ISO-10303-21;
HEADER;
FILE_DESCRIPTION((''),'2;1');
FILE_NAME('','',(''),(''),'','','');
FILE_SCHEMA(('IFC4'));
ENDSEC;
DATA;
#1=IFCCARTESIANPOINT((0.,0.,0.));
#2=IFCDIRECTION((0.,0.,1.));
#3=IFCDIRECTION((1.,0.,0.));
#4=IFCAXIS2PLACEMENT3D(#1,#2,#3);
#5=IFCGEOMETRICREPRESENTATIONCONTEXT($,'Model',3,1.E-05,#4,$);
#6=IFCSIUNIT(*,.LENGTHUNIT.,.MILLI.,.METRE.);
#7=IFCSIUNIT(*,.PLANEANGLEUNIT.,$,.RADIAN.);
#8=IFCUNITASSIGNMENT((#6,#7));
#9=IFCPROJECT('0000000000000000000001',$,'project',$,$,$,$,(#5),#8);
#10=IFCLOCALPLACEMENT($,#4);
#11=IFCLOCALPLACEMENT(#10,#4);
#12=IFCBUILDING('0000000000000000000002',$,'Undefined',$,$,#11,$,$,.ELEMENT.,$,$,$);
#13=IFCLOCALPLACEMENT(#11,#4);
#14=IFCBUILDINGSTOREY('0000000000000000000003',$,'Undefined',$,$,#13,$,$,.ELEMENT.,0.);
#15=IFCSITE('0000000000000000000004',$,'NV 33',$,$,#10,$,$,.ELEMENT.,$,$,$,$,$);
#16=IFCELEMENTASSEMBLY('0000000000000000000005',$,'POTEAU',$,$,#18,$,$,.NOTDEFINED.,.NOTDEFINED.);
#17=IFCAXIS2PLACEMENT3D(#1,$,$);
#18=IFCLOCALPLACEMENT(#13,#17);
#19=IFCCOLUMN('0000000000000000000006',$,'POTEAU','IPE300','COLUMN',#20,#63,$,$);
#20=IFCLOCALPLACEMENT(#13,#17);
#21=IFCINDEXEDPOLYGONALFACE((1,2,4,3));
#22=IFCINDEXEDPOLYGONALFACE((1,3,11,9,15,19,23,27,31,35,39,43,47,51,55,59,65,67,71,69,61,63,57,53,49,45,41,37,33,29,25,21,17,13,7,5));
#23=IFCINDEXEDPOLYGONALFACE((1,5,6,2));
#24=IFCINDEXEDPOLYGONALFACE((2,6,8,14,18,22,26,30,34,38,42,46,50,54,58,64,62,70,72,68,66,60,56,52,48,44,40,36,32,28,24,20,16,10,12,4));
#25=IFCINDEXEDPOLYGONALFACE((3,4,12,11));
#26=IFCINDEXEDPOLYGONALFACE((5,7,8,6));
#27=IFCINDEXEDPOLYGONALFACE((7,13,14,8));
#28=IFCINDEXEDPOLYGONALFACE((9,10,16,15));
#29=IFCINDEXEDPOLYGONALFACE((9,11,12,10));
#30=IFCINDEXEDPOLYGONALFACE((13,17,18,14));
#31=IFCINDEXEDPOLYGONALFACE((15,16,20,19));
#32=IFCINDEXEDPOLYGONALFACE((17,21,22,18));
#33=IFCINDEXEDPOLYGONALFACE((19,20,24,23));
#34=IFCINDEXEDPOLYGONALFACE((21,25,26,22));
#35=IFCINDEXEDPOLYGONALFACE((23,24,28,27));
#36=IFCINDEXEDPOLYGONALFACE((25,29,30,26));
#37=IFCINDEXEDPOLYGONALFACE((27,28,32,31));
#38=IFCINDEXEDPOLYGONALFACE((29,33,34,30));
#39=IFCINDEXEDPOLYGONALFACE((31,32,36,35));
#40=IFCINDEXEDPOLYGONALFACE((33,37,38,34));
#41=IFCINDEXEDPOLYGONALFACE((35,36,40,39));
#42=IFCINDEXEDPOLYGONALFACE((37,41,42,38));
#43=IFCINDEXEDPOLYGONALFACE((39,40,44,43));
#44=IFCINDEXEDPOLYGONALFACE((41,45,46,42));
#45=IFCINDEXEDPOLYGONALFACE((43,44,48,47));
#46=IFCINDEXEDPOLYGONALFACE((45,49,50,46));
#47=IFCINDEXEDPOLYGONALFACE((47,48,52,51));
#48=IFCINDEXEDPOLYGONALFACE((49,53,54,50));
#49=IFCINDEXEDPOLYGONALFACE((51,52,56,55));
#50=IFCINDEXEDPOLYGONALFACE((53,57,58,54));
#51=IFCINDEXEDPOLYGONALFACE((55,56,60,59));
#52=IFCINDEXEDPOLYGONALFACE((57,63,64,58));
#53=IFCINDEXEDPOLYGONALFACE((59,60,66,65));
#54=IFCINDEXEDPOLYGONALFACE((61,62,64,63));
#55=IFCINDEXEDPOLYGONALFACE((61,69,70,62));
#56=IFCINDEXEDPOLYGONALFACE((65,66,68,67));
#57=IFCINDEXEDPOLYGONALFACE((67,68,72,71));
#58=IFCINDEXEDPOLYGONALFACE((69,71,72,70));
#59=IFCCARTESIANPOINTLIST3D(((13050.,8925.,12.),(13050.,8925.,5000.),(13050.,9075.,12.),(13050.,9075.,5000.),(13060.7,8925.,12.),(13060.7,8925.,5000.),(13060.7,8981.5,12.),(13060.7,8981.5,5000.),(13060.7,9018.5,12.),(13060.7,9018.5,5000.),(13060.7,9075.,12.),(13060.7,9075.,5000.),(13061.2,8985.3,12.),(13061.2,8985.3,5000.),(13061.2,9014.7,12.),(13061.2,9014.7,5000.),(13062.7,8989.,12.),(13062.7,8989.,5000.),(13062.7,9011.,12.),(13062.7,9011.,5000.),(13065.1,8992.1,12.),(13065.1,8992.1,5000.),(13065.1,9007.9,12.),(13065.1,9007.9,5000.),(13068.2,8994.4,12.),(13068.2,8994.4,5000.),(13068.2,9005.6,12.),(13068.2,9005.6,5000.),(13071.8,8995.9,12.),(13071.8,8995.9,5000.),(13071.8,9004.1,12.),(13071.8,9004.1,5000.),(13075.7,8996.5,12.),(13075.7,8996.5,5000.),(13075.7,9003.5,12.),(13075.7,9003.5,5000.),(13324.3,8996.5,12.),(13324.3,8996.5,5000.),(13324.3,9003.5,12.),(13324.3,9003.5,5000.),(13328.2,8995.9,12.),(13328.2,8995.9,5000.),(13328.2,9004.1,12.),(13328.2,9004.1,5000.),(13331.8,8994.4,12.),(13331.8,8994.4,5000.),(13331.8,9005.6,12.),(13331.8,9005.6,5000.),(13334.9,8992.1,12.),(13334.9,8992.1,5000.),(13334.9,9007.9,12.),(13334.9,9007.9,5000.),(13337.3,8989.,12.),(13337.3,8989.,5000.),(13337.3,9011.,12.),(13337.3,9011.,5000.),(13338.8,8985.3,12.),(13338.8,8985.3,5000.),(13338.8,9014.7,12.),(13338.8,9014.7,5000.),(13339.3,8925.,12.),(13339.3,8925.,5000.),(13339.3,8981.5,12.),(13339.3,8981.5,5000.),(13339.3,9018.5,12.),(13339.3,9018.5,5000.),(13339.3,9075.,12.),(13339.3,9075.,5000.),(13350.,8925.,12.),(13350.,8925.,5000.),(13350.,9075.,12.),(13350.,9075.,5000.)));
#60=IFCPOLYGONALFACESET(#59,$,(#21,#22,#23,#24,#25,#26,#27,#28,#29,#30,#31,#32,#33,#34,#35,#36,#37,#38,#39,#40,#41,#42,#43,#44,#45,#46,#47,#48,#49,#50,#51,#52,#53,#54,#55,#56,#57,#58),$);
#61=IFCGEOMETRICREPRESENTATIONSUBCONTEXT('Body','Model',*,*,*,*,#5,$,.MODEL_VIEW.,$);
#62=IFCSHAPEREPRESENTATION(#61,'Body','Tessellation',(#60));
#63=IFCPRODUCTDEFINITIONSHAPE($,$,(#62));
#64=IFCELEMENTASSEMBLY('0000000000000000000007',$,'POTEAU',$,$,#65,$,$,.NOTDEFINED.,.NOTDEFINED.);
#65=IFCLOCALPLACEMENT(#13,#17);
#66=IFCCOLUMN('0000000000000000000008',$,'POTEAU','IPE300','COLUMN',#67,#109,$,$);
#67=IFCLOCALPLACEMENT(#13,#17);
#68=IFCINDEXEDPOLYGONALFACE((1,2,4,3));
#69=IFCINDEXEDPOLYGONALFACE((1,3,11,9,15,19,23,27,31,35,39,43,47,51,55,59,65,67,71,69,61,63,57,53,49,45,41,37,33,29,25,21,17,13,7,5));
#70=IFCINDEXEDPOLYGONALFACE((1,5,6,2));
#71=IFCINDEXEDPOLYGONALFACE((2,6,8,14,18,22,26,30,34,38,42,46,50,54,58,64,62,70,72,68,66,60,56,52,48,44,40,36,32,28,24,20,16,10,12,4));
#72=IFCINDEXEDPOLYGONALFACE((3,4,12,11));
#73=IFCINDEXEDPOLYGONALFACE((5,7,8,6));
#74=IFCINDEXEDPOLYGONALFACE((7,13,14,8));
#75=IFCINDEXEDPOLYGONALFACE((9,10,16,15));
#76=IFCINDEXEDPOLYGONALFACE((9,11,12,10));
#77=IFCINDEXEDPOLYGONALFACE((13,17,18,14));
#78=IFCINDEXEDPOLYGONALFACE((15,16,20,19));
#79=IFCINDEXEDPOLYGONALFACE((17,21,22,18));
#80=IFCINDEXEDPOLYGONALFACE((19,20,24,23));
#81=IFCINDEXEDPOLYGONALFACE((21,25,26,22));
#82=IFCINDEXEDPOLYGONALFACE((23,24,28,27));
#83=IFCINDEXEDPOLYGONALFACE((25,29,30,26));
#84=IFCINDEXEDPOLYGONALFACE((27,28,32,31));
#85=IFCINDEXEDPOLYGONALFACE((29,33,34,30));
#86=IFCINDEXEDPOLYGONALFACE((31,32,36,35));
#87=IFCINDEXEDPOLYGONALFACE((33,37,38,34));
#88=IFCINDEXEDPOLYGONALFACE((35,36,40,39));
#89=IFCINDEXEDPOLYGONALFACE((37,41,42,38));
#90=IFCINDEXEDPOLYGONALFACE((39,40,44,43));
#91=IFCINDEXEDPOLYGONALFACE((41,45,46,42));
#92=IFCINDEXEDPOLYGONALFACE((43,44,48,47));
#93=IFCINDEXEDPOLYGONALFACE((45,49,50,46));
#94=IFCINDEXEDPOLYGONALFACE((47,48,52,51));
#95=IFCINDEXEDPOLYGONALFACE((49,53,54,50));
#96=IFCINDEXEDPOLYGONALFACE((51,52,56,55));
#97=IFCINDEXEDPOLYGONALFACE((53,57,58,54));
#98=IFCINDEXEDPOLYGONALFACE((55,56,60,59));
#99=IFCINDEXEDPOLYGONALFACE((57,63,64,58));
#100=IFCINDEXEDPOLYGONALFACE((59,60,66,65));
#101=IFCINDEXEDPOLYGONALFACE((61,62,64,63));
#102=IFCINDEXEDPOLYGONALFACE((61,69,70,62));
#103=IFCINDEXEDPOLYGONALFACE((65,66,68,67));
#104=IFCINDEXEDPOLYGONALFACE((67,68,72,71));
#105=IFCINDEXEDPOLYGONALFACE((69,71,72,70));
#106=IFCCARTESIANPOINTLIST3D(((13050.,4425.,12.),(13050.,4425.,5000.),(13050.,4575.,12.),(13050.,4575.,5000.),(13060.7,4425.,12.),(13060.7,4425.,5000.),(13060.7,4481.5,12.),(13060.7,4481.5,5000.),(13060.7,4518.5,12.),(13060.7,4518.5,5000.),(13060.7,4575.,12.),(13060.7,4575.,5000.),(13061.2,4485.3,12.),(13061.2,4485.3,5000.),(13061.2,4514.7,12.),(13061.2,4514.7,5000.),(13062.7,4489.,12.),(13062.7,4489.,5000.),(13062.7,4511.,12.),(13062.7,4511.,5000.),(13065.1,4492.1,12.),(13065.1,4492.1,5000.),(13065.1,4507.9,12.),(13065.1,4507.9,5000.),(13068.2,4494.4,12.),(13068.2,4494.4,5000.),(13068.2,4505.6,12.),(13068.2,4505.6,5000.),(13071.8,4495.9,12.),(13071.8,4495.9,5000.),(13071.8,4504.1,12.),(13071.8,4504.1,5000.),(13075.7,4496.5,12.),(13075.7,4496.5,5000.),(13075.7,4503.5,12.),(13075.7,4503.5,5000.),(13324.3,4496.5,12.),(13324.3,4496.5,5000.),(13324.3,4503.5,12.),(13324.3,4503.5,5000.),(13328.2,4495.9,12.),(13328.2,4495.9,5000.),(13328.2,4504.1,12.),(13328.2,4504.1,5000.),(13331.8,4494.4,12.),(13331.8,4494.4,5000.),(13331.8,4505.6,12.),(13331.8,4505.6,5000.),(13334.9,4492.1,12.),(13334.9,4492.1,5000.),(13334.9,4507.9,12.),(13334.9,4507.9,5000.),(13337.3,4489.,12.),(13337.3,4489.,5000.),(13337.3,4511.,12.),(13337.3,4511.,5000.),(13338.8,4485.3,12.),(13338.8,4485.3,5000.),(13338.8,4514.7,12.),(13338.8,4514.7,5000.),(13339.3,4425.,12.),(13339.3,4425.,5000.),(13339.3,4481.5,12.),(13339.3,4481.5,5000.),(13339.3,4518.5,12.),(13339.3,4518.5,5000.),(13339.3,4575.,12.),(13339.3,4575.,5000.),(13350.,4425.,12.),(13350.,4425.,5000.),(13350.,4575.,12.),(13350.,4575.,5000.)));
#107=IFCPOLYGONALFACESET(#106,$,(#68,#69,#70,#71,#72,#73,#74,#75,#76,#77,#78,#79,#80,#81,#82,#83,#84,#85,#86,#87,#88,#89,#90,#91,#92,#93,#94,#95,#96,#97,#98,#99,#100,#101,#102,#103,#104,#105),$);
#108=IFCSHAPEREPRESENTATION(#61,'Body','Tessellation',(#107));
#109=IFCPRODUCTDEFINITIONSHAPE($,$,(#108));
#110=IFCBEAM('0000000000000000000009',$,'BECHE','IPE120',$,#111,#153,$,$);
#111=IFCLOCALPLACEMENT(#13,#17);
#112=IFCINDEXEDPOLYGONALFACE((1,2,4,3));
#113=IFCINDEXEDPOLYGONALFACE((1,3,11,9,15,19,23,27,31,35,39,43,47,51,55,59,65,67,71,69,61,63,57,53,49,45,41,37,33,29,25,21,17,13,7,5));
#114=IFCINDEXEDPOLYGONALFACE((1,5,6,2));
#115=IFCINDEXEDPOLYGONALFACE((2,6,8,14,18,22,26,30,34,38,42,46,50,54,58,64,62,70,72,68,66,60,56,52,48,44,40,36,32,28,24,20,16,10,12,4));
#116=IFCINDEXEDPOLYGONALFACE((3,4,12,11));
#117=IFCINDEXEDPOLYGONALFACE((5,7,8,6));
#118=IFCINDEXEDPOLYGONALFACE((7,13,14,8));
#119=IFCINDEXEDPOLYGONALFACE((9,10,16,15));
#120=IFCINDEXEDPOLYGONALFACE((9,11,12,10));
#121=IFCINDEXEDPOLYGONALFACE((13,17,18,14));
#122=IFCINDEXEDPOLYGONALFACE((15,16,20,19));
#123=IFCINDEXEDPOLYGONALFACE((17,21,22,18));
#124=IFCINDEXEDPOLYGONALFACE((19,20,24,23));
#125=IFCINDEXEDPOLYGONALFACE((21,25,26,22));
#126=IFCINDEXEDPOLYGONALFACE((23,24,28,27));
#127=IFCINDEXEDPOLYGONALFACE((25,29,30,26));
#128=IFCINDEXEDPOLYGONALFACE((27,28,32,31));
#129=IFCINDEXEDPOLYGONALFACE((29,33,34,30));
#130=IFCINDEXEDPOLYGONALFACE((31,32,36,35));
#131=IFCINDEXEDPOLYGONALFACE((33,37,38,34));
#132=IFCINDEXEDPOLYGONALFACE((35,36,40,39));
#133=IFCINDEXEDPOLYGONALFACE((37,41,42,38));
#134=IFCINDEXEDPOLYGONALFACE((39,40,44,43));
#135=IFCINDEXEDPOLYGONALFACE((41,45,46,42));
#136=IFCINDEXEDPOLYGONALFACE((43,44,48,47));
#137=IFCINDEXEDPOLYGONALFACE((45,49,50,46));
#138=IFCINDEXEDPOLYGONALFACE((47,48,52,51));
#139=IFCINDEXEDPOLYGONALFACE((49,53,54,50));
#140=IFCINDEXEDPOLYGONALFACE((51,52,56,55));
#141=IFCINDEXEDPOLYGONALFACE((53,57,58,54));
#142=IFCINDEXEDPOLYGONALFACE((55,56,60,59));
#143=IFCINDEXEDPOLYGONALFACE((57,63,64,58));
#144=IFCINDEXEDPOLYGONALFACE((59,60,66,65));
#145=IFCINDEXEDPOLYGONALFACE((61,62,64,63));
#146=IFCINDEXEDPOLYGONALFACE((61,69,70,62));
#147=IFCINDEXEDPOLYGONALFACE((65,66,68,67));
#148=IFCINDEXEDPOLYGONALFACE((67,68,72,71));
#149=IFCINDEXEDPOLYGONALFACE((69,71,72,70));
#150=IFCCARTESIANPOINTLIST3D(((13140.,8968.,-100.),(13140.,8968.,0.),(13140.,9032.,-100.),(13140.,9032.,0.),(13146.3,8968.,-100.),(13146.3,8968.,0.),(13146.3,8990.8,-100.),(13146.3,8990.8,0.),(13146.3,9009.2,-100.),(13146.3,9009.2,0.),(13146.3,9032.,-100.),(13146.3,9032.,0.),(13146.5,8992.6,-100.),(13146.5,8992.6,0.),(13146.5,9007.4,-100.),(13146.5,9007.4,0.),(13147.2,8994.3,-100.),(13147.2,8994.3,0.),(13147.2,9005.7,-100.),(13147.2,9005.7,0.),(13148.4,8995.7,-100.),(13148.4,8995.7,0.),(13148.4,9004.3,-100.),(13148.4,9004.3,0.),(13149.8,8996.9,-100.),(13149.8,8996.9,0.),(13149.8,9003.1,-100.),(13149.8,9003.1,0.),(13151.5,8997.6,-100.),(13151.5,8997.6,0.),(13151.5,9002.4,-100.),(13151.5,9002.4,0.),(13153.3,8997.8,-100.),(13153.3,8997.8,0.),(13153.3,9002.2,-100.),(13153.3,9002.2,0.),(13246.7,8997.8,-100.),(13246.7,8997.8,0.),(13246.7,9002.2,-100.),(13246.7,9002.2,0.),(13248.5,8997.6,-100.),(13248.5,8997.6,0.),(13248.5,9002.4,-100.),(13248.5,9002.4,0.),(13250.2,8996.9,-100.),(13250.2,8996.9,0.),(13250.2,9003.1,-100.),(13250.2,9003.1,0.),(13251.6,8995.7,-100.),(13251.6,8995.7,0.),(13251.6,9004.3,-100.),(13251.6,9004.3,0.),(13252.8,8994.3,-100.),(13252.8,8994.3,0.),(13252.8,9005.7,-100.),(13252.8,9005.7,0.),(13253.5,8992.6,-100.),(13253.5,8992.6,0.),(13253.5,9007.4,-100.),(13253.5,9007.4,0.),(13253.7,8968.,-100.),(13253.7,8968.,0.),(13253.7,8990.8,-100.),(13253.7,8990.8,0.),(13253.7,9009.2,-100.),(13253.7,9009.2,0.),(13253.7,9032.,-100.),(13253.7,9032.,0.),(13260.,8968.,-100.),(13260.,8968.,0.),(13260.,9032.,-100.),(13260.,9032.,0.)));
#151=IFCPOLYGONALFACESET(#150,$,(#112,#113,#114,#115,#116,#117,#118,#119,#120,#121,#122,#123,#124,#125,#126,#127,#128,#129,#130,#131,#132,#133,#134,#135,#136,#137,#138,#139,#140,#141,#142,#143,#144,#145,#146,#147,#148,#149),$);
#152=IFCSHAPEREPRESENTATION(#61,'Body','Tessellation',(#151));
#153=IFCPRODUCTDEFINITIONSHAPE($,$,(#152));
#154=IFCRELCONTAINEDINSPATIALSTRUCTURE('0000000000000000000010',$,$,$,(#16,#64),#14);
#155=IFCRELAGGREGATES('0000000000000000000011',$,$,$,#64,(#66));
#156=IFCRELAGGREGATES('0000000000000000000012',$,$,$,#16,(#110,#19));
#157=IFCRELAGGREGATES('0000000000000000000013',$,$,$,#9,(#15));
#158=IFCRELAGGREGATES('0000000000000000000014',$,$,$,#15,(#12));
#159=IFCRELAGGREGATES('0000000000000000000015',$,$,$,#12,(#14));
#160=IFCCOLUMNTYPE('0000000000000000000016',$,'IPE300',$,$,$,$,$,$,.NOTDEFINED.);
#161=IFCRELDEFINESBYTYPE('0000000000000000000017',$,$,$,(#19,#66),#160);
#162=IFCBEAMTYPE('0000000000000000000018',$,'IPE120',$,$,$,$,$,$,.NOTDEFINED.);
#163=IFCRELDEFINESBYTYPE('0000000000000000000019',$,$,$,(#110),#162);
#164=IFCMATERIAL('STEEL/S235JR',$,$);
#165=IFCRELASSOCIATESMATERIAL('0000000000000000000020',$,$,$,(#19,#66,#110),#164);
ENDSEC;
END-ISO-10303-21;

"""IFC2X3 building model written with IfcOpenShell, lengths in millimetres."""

from ifc_helpers import new_model, si_unit, frame, origin_with_axes, origin_2d_with_axis, place, context, subcontext, project, spatial, i_section, extrude, clip, halfspace, material, type_object, element, aggregate, save


model = new_model("IFC2X3")

# Units and contexts
model_context = context("Model", 3, precision=1e-05, world=origin_with_axes())
body_context = subcontext(model_context, "Body", "Model", "MODEL_VIEW")
ifc_project = project(units=[si_unit("LENGTHUNIT", "METRE", prefix="MILLI"), si_unit("PLANEANGLEUNIT", "RADIAN")], contexts=[model_context])

# Site, building, storey
site_placement = place(None, origin_with_axes())
site = spatial("IfcSite", under=ifc_project, at=site_placement, Name="NV 33", CompositionType="ELEMENT")
building_placement = place(site_placement, origin_with_axes())
building = spatial("IfcBuilding", under=site, at=building_placement, Name="Undefined", CompositionType="ELEMENT")
storey_placement = place(building_placement, origin_with_axes())
storey = spatial("IfcBuildingStorey", under=building, at=storey_placement, Name="Undefined", CompositionType="ELEMENT", Elevation=0.0)

# Element assemblies, columns
assembly_1_placement = place(storey_placement, origin_with_axes())
assembly_1 = element("IfcElementAssembly", 1, at=assembly_1_placement, inside=storey, Name="POTEAU", AssemblyPlace="NOTDEFINED", PredefinedType="NOTDEFINED")
ifc_material_1 = material(Name="STEEL/S235JR")
column_type = type_object("IfcColumnType", Name="IPE300", PredefinedType="NOTDEFINED")
column_1_placement = place(assembly_1_placement, frame((13200.0, 9000.0, 0.0), z_axis=(0.0, 0.0, 1.0), x_axis=(-1.0, 0.0, 0.0)))
column_1 = element("IfcColumn", 2, at=column_1_placement, type_object=column_type, material=ifc_material_1, Name="POTEAU", Description="IPE300", ObjectType="COLUMN", context=body_context, shape_type="Clipping", body=[
    clip(clip(extrude(i_section(OverallWidth=150.0, OverallDepth=300.0, WebThickness=7.1, FlangeThickness=10.7, FilletRadius=15.0, at=origin_2d_with_axis()), frame((0.0, 0.0, 5000.0), z_axis=(0.0, 0.0, -1.0), x_axis=(0.0, 1.0, 0.0)), (0.0, 0.0, 1.0), 5000.0), halfspace(frame((-150.0, 0.0, 5000.0), z_axis=(0.0, 0.0, -1.0), x_axis=(0.0, -1.0, 0.0)), True)), halfspace(frame((-150.0, 0.0, 12.0), z_axis=(0.0, 0.0, 1.0), x_axis=(0.0, 1.0, 0.0)), True)),
])
assembly_2_placement = place(storey_placement, origin_with_axes())
assembly_2 = element("IfcElementAssembly", 3, at=assembly_2_placement, inside=storey, Name="POTEAU", AssemblyPlace="NOTDEFINED", PredefinedType="NOTDEFINED")
column_2_placement = place(assembly_2_placement, frame((13200.0, 4500.0, 0.0), z_axis=(0.0, 0.0, 1.0), x_axis=(-1.0, 0.0, 0.0)))
column_2 = element("IfcColumn", 4, at=column_2_placement, type_object=column_type, material=ifc_material_1, Name="POTEAU", Description="IPE300", ObjectType="COLUMN", context=body_context, shape_type="Clipping", body=[
    clip(clip(extrude(i_section(OverallWidth=150.0, OverallDepth=300.0, WebThickness=7.1, FlangeThickness=10.7, FilletRadius=15.0, at=origin_2d_with_axis()), frame((0.0, 0.0, 5000.0), z_axis=(0.0, 0.0, -1.0), x_axis=(0.0, 1.0, 0.0)), (0.0, 0.0, 1.0), 5000.0), halfspace(frame((-150.0, 0.0, 5000.0), z_axis=(0.0, 0.0, -1.0), x_axis=(0.0, -1.0, 0.0)), True)), halfspace(frame((-150.0, 0.0, 12.0), z_axis=(0.0, 0.0, 1.0), x_axis=(0.0, 1.0, 0.0)), True)),
])

# Beam
beam_type_1 = type_object("IfcBeamType", Name="IPE120", PredefinedType="NOTDEFINED")
beam_1_placement = place(assembly_1_placement, frame((13200.0, 9000.0, 0.0), z_axis=(-1.0, 0.0, 0.0), x_axis=(0.0, 0.0, -1.0)))
beam_1 = element("IfcBeam", 5, at=beam_1_placement, type_object=beam_type_1, material=ifc_material_1, Name="BECHE", Description="IPE120", context=body_context, shape_type="SweptSolid", body=[
    extrude(i_section(OverallWidth=64.0, OverallDepth=120.0, WebThickness=4.4, FlangeThickness=6.3, FilletRadius=7.0, at=origin_2d_with_axis()), frame((100.0, 0.0, 0.0), z_axis=(-1.0, 0.0, 0.0), x_axis=(0.0, -1.0, 0.0)), (0.0, 0.0, 1.0), 100.0),
])

aggregate(assembly_2, [column_2])

aggregate(assembly_1, [beam_1, column_1])

save(model, "model.ifc")
